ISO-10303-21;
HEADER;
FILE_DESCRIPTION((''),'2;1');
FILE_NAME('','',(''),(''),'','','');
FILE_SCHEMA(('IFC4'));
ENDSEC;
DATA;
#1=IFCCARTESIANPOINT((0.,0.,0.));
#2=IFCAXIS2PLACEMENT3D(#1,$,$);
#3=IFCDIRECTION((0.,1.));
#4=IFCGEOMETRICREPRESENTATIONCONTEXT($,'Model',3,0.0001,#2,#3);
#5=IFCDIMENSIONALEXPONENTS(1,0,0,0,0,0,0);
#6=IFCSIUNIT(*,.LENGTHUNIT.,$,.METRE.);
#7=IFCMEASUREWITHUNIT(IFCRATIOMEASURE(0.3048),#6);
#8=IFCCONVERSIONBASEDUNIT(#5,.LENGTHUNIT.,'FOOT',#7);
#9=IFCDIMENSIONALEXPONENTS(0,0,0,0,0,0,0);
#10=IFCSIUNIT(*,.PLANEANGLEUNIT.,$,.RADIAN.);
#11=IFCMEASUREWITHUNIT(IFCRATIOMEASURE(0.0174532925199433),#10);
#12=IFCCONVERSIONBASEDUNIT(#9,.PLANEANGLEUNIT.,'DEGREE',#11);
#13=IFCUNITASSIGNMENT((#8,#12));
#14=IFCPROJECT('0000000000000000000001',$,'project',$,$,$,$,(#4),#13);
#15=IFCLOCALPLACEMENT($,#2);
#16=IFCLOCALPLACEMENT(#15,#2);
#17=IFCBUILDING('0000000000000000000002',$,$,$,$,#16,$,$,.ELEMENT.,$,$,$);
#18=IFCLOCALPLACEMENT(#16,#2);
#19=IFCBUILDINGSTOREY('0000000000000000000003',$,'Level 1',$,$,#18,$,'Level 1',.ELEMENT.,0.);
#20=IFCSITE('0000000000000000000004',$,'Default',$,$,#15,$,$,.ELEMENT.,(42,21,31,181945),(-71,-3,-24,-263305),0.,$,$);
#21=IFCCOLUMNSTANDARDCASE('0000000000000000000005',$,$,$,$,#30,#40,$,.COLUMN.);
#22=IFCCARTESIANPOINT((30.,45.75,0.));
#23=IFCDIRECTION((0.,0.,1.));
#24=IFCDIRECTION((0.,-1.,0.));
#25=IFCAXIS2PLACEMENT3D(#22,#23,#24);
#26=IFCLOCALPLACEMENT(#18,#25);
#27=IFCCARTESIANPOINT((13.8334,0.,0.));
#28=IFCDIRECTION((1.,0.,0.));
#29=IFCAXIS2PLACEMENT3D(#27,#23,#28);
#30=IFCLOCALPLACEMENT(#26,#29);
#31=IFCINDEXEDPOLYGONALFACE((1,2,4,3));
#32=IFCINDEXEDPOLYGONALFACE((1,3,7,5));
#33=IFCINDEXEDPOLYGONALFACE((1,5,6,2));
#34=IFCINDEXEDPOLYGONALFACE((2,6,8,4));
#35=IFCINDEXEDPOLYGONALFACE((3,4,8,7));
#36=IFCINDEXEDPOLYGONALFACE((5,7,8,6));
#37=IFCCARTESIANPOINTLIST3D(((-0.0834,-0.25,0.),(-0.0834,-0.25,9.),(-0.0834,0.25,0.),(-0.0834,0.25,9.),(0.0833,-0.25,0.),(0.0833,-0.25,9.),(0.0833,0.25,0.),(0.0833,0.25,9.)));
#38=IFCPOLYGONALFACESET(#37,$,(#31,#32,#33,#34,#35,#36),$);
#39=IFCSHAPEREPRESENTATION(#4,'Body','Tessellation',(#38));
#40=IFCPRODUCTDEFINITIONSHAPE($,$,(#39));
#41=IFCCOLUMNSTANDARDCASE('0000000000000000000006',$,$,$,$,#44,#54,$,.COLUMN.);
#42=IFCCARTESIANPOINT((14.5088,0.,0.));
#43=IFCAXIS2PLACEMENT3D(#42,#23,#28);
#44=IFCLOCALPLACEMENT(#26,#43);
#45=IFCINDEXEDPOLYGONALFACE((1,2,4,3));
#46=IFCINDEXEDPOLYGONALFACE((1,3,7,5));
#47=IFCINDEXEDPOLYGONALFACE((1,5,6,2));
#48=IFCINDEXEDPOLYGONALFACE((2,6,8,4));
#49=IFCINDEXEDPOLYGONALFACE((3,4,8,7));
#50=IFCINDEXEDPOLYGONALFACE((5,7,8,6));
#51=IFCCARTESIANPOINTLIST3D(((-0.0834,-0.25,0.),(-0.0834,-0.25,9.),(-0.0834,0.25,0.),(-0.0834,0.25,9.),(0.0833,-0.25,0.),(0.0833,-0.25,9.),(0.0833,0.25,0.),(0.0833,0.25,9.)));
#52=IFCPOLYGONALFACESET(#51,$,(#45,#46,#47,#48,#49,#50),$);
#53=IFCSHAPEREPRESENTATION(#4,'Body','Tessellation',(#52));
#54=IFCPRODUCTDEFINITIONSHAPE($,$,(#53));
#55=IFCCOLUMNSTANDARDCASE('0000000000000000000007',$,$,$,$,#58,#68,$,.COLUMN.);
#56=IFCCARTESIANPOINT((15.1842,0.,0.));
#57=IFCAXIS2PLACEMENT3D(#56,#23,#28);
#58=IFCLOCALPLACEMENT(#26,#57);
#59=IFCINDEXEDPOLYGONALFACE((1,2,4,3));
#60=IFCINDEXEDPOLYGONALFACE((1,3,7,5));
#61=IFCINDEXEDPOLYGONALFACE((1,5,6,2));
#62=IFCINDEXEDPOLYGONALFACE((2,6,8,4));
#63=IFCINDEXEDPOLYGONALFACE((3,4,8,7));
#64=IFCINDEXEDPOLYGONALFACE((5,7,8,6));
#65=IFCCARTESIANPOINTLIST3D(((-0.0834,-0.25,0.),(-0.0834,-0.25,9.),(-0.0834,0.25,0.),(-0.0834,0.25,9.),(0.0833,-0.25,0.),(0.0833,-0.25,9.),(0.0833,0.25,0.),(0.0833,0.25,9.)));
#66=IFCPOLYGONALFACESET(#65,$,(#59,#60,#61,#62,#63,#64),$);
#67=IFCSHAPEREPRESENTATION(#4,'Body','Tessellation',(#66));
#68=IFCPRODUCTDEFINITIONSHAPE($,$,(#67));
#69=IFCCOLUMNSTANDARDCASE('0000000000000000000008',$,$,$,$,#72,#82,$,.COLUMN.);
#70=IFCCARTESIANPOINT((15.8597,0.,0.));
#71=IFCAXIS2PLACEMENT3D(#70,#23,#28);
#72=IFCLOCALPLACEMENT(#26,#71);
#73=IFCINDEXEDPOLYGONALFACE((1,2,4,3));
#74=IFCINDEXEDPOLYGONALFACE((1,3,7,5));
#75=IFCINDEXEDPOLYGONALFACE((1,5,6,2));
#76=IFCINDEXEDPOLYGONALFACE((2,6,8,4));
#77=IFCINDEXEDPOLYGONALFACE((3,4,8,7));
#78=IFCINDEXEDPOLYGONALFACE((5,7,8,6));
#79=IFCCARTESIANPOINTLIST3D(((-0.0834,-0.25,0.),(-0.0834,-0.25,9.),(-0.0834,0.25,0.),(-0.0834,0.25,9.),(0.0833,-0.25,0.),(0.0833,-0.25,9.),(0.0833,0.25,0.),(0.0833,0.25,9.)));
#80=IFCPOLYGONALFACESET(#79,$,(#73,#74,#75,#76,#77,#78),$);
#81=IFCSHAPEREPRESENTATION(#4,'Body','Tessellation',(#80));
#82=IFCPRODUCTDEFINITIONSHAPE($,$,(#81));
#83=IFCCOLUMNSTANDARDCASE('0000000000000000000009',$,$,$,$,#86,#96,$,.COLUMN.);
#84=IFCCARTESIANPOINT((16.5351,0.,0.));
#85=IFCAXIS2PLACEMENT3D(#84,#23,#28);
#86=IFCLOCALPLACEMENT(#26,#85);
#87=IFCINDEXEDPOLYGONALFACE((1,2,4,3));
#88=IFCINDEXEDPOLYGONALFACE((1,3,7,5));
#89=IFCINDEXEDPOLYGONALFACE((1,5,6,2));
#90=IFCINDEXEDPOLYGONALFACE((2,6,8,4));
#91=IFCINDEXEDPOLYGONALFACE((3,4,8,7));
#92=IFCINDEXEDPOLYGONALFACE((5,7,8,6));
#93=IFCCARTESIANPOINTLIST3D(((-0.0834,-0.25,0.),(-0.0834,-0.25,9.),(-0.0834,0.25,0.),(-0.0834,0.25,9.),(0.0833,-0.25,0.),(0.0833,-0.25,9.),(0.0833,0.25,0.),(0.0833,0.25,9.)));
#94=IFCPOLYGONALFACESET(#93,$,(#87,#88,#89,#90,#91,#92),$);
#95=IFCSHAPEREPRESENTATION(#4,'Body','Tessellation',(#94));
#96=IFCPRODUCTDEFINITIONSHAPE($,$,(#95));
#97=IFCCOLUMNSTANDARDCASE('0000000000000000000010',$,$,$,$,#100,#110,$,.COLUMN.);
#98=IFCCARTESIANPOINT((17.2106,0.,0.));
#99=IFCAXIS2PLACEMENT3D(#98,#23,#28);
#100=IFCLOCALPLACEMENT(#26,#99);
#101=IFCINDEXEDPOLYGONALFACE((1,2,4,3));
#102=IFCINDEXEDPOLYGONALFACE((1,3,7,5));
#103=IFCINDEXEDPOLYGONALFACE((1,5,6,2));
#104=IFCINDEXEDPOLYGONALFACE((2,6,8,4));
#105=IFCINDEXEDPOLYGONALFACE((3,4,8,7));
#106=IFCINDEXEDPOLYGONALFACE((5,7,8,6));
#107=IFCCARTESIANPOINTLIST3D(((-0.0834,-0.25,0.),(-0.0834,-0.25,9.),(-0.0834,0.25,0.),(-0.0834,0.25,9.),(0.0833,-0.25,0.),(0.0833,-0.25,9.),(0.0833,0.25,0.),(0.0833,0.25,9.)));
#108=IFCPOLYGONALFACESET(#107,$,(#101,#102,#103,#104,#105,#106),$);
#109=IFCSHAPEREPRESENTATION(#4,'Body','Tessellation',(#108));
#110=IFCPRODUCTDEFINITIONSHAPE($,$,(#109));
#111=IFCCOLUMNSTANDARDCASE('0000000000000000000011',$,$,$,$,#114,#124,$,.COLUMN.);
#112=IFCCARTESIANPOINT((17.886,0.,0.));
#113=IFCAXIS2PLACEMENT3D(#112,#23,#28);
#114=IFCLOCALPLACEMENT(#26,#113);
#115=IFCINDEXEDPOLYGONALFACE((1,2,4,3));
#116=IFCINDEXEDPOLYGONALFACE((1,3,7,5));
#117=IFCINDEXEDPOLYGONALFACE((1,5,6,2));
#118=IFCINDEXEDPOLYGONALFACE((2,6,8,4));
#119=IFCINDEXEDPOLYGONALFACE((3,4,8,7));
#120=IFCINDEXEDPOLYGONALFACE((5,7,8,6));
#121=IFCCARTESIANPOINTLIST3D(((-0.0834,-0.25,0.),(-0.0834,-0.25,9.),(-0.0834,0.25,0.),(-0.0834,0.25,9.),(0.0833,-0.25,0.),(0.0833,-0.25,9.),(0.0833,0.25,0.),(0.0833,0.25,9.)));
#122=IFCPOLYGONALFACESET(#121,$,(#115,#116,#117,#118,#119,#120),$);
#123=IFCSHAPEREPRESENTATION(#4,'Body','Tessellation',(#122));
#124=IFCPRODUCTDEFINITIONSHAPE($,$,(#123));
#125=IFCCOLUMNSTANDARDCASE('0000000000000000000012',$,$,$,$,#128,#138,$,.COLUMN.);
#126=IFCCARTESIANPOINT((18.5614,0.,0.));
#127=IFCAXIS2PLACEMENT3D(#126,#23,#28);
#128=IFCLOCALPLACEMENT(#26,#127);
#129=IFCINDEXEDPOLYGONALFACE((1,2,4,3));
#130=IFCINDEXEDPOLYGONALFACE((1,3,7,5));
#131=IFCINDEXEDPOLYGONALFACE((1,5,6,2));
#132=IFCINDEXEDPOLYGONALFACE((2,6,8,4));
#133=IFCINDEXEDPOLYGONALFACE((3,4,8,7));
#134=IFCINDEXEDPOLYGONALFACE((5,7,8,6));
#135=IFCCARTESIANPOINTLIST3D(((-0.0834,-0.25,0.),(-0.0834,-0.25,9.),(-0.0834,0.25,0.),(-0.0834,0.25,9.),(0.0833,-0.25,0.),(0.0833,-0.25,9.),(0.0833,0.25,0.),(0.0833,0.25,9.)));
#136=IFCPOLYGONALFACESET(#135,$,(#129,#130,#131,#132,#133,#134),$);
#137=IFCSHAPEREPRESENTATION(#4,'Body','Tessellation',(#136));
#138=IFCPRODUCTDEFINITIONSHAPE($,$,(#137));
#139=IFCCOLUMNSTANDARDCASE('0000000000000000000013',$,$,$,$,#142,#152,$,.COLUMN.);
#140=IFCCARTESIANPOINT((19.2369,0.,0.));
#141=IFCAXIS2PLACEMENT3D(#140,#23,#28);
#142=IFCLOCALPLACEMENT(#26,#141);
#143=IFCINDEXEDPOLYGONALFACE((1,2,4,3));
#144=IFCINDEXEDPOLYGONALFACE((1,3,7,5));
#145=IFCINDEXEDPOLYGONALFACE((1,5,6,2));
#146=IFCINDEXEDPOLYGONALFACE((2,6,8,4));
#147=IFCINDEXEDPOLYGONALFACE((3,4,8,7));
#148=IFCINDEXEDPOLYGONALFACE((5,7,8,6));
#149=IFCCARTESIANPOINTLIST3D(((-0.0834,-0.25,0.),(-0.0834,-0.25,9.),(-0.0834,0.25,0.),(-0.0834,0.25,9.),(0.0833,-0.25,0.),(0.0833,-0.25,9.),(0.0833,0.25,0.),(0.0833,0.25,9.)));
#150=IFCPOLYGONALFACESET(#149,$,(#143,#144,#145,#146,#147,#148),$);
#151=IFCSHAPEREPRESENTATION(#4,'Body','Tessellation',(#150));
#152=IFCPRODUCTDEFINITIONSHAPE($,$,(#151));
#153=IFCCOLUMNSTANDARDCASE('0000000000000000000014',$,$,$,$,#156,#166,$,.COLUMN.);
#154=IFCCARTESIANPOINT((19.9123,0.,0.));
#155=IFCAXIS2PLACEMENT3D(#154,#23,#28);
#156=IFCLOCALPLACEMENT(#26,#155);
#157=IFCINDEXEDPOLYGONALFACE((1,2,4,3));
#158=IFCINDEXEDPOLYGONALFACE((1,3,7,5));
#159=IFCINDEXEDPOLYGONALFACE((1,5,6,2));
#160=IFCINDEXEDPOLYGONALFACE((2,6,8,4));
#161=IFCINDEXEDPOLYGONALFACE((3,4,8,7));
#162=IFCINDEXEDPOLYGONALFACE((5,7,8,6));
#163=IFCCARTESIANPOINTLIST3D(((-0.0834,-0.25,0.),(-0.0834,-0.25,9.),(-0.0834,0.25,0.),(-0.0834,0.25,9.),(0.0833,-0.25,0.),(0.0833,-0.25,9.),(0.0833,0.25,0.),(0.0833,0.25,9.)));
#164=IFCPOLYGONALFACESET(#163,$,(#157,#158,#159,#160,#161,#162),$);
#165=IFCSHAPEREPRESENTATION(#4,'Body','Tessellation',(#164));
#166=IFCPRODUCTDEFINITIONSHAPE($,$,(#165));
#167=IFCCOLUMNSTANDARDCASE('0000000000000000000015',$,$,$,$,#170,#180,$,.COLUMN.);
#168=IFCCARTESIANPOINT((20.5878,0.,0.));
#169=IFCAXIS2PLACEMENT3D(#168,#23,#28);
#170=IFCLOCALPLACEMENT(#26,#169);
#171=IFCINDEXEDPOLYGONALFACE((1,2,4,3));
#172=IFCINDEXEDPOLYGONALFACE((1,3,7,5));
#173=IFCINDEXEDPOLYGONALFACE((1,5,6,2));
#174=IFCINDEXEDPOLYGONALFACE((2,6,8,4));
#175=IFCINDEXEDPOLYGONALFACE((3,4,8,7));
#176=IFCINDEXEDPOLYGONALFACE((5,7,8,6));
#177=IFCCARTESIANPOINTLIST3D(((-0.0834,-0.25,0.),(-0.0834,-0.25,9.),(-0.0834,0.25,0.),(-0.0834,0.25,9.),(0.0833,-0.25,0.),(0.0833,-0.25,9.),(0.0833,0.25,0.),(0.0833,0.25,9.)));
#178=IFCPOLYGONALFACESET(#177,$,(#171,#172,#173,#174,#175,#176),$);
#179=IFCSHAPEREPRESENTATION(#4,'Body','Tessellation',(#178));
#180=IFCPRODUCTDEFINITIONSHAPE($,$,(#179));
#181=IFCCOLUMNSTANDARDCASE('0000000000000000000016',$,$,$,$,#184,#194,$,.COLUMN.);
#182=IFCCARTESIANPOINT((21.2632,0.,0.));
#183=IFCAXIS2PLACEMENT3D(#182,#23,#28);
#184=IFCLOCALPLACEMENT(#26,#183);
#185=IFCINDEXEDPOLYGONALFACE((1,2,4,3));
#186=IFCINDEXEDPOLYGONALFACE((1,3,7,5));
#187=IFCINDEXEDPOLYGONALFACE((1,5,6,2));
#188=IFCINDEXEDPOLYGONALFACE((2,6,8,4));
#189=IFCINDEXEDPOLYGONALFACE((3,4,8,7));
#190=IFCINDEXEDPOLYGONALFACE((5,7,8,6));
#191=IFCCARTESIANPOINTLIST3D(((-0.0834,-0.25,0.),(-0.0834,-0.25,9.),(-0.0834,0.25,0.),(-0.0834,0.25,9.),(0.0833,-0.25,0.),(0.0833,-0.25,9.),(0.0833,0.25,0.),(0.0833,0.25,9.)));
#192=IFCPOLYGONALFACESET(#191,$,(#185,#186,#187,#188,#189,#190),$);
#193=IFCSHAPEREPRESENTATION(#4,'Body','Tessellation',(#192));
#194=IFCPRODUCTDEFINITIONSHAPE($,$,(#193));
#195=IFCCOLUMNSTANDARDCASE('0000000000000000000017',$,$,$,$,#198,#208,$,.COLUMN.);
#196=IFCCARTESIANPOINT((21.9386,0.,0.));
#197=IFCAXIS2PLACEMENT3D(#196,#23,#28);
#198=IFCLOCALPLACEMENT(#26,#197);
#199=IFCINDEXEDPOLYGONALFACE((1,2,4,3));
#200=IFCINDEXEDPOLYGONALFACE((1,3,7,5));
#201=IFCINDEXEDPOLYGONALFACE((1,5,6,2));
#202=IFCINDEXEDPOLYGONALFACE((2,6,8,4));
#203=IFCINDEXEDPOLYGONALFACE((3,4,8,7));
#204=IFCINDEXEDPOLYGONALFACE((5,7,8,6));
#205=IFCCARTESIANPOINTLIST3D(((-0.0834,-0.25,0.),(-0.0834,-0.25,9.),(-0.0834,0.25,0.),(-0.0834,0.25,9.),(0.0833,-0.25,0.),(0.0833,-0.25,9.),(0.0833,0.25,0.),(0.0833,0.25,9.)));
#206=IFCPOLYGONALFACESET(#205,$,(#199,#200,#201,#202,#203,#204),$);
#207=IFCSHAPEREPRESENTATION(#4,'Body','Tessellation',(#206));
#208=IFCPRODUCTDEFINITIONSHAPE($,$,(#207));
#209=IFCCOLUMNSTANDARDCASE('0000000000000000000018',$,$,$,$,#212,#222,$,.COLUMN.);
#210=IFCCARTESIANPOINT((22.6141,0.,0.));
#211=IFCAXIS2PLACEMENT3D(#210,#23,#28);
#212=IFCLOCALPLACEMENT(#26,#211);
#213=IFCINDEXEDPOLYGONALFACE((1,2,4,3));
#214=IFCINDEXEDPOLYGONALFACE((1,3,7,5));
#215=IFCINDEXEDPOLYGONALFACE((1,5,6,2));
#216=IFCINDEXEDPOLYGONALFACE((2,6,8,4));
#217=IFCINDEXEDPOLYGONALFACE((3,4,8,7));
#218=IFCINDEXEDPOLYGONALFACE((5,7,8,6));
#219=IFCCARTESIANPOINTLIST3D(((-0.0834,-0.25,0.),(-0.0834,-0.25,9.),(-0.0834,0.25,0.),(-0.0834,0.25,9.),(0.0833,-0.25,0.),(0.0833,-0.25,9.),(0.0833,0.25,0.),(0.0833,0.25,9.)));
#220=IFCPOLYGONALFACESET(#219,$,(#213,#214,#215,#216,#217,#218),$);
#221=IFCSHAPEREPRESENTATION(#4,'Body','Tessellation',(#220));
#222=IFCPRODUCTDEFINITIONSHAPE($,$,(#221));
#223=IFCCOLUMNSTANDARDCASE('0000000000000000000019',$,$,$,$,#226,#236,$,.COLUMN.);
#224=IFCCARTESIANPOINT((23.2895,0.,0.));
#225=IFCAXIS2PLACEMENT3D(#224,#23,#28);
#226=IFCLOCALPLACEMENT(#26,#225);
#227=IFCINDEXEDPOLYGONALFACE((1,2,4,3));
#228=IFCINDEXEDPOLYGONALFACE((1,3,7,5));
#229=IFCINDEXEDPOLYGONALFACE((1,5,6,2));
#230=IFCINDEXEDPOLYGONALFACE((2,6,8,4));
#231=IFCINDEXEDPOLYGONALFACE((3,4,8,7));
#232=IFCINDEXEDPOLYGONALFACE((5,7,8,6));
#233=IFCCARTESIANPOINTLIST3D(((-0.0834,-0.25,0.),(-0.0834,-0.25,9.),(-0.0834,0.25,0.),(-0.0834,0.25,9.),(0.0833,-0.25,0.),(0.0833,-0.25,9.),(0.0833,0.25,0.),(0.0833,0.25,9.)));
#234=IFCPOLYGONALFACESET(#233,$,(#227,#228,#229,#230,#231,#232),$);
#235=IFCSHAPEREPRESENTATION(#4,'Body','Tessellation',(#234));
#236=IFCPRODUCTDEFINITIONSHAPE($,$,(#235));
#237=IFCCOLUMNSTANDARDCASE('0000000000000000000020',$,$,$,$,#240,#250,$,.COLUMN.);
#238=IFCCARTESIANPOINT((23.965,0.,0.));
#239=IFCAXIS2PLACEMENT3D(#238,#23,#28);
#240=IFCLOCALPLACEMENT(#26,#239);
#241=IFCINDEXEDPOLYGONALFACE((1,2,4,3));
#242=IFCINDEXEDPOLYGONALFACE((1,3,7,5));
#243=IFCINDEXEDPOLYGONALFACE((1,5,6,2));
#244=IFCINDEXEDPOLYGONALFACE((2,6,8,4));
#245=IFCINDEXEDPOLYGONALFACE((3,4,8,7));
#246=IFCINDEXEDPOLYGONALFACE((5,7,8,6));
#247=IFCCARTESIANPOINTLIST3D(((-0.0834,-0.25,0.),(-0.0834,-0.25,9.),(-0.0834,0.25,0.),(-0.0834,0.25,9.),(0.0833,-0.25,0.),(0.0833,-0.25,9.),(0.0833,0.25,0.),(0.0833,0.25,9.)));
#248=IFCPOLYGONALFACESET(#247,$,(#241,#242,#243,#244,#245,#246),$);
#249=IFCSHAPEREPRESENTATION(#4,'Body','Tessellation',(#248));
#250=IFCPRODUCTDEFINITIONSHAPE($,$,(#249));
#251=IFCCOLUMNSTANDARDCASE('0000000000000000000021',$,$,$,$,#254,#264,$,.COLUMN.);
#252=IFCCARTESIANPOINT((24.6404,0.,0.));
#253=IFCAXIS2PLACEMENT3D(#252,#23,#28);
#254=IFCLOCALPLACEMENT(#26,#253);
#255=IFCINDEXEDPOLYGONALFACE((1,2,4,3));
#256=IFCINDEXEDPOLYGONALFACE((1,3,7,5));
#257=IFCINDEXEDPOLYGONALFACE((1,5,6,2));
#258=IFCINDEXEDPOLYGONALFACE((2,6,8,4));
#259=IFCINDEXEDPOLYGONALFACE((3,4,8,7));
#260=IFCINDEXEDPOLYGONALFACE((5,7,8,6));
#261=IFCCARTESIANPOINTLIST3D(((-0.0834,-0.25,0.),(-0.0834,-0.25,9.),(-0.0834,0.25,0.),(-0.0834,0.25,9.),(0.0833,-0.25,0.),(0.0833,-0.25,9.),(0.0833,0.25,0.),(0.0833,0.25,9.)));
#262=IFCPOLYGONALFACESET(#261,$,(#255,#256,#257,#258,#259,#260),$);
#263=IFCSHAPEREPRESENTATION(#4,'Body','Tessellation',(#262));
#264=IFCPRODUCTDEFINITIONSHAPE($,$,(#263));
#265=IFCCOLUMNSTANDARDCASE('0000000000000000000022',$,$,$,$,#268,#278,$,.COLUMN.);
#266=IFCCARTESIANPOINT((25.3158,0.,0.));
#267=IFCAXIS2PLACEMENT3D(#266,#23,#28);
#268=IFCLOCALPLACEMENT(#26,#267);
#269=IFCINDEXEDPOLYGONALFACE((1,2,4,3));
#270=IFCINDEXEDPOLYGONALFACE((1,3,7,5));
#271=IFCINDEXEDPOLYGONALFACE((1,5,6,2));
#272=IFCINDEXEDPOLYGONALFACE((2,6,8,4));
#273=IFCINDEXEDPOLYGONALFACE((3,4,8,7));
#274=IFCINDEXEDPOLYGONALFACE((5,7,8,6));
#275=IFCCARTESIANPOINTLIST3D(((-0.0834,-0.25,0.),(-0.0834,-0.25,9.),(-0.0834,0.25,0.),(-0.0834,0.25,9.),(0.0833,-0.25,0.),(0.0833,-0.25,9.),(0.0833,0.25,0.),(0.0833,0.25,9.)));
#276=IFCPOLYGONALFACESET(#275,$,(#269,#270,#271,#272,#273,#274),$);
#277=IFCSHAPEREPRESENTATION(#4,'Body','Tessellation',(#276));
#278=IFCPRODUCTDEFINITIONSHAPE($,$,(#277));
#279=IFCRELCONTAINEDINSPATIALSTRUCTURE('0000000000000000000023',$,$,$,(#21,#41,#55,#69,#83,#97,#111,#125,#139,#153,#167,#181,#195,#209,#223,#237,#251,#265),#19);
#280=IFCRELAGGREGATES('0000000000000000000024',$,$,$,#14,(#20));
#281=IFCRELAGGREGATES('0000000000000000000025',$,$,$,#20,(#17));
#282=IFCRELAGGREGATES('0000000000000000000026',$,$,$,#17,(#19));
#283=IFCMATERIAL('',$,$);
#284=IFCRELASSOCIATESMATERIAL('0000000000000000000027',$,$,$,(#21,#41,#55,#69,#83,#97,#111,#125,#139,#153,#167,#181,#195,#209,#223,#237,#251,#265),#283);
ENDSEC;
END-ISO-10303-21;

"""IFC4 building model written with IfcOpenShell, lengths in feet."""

from ifc_helpers import new_model, entity, si_unit, converted_unit, direction, frame, origin, place, context, project, spatial, rectangle, extrude, material, element, save


model = new_model("IFC4")

# Units and contexts
model_context = context("Model", 3, precision=0.0001, world=origin(), true_north=direction((0.0, 1.0)))
ifc_project = project(units=[converted_unit("LENGTHUNIT", "FOOT", entity("IfcRatioMeasure", 0.3048), si_unit("LENGTHUNIT", "METRE"), dimensions=[1, 0, 0, 0, 0, 0, 0]), converted_unit("PLANEANGLEUNIT", "DEGREE", entity("IfcRatioMeasure", 0.0174532925199433), si_unit("PLANEANGLEUNIT", "RADIAN"), dimensions=[0, 0, 0, 0, 0, 0, 0])], contexts=[model_context])

# Site, building, storey
site_placement = place(None, origin())
site = spatial("IfcSite", under=ifc_project, at=site_placement, Name="Default", CompositionType="ELEMENT", RefLatitude=(42, 21, 31, 181945), RefLongitude=(-71, -3, -24, -263305), RefElevation=0.0)
building_placement = place(site_placement, origin())
building = spatial("IfcBuilding", under=site, at=building_placement, CompositionType="ELEMENT")
storey_placement = place(building_placement, origin())
storey = spatial("IfcBuildingStorey", under=building, at=storey_placement, Name="Level 1", LongName="Level 1", CompositionType="ELEMENT", Elevation=0.0)

# Columns
ifc_material_1 = material(Name="")
placement_1 = place(storey_placement, frame((30.0, 45.75, 0.0), z_axis=(0.0, 0.0, 1.0), x_axis=(0.0, -1.0, 0.0)))
for number, where, z_axis, x_axis in (
    (1, (13.8334, 0.0, 0.0), (0.0, 0.0, 1.0), (1.0, 0.0, 0.0)),
    (2, (14.5088, 0.0, 0.0), (0.0, 0.0, 1.0), (1.0, 0.0, 0.0)),
    (3, (15.1842, 0.0, 0.0), (0.0, 0.0, 1.0), (1.0, 0.0, 0.0)),
    (4, (15.8597, 0.0, 0.0), (0.0, 0.0, 1.0), (1.0, 0.0, 0.0)),
    (5, (16.5351, 0.0, 0.0), (0.0, 0.0, 1.0), (1.0, 0.0, 0.0)),
    (6, (17.2106, 0.0, 0.0), (0.0, 0.0, 1.0), (1.0, 0.0, 0.0)),
    (7, (17.886, 0.0, 0.0), (0.0, 0.0, 1.0), (1.0, 0.0, 0.0)),
    (8, (18.5614, 0.0, 0.0), (0.0, 0.0, 1.0), (1.0, 0.0, 0.0)),
    (9, (19.2369, 0.0, 0.0), (0.0, 0.0, 1.0), (1.0, 0.0, 0.0)),
    (10, (19.9123, 0.0, 0.0), (0.0, 0.0, 1.0), (1.0, 0.0, 0.0)),
    (11, (20.5878, 0.0, 0.0), (0.0, 0.0, 1.0), (1.0, 0.0, 0.0)),
    (12, (21.2632, 0.0, 0.0), (0.0, 0.0, 1.0), (1.0, 0.0, 0.0)),
    (13, (21.9386, 0.0, 0.0), (0.0, 0.0, 1.0), (1.0, 0.0, 0.0)),
    (14, (22.6141, 0.0, 0.0), (0.0, 0.0, 1.0), (1.0, 0.0, 0.0)),
    (15, (23.2895, 0.0, 0.0), (0.0, 0.0, 1.0), (1.0, 0.0, 0.0)),
    (16, (23.965, 0.0, 0.0), (0.0, 0.0, 1.0), (1.0, 0.0, 0.0)),
    (17, (24.6404, 0.0, 0.0), (0.0, 0.0, 1.0), (1.0, 0.0, 0.0)),
    (18, (25.3158, 0.0, 0.0), (0.0, 0.0, 1.0), (1.0, 0.0, 0.0)),
):
    element("IfcColumnStandardCase", number, at=place(placement_1, frame(where, z_axis=z_axis, x_axis=x_axis)), inside=storey, material=ifc_material_1, PredefinedType="COLUMN", context=model_context, shape_type="SweptSolid", body=[
        extrude(rectangle(XDim=0.1667, YDim=0.5), origin(), (0.0, 0.0, 1.0), 9.0),
    ])

save(model, "model.ifc")
